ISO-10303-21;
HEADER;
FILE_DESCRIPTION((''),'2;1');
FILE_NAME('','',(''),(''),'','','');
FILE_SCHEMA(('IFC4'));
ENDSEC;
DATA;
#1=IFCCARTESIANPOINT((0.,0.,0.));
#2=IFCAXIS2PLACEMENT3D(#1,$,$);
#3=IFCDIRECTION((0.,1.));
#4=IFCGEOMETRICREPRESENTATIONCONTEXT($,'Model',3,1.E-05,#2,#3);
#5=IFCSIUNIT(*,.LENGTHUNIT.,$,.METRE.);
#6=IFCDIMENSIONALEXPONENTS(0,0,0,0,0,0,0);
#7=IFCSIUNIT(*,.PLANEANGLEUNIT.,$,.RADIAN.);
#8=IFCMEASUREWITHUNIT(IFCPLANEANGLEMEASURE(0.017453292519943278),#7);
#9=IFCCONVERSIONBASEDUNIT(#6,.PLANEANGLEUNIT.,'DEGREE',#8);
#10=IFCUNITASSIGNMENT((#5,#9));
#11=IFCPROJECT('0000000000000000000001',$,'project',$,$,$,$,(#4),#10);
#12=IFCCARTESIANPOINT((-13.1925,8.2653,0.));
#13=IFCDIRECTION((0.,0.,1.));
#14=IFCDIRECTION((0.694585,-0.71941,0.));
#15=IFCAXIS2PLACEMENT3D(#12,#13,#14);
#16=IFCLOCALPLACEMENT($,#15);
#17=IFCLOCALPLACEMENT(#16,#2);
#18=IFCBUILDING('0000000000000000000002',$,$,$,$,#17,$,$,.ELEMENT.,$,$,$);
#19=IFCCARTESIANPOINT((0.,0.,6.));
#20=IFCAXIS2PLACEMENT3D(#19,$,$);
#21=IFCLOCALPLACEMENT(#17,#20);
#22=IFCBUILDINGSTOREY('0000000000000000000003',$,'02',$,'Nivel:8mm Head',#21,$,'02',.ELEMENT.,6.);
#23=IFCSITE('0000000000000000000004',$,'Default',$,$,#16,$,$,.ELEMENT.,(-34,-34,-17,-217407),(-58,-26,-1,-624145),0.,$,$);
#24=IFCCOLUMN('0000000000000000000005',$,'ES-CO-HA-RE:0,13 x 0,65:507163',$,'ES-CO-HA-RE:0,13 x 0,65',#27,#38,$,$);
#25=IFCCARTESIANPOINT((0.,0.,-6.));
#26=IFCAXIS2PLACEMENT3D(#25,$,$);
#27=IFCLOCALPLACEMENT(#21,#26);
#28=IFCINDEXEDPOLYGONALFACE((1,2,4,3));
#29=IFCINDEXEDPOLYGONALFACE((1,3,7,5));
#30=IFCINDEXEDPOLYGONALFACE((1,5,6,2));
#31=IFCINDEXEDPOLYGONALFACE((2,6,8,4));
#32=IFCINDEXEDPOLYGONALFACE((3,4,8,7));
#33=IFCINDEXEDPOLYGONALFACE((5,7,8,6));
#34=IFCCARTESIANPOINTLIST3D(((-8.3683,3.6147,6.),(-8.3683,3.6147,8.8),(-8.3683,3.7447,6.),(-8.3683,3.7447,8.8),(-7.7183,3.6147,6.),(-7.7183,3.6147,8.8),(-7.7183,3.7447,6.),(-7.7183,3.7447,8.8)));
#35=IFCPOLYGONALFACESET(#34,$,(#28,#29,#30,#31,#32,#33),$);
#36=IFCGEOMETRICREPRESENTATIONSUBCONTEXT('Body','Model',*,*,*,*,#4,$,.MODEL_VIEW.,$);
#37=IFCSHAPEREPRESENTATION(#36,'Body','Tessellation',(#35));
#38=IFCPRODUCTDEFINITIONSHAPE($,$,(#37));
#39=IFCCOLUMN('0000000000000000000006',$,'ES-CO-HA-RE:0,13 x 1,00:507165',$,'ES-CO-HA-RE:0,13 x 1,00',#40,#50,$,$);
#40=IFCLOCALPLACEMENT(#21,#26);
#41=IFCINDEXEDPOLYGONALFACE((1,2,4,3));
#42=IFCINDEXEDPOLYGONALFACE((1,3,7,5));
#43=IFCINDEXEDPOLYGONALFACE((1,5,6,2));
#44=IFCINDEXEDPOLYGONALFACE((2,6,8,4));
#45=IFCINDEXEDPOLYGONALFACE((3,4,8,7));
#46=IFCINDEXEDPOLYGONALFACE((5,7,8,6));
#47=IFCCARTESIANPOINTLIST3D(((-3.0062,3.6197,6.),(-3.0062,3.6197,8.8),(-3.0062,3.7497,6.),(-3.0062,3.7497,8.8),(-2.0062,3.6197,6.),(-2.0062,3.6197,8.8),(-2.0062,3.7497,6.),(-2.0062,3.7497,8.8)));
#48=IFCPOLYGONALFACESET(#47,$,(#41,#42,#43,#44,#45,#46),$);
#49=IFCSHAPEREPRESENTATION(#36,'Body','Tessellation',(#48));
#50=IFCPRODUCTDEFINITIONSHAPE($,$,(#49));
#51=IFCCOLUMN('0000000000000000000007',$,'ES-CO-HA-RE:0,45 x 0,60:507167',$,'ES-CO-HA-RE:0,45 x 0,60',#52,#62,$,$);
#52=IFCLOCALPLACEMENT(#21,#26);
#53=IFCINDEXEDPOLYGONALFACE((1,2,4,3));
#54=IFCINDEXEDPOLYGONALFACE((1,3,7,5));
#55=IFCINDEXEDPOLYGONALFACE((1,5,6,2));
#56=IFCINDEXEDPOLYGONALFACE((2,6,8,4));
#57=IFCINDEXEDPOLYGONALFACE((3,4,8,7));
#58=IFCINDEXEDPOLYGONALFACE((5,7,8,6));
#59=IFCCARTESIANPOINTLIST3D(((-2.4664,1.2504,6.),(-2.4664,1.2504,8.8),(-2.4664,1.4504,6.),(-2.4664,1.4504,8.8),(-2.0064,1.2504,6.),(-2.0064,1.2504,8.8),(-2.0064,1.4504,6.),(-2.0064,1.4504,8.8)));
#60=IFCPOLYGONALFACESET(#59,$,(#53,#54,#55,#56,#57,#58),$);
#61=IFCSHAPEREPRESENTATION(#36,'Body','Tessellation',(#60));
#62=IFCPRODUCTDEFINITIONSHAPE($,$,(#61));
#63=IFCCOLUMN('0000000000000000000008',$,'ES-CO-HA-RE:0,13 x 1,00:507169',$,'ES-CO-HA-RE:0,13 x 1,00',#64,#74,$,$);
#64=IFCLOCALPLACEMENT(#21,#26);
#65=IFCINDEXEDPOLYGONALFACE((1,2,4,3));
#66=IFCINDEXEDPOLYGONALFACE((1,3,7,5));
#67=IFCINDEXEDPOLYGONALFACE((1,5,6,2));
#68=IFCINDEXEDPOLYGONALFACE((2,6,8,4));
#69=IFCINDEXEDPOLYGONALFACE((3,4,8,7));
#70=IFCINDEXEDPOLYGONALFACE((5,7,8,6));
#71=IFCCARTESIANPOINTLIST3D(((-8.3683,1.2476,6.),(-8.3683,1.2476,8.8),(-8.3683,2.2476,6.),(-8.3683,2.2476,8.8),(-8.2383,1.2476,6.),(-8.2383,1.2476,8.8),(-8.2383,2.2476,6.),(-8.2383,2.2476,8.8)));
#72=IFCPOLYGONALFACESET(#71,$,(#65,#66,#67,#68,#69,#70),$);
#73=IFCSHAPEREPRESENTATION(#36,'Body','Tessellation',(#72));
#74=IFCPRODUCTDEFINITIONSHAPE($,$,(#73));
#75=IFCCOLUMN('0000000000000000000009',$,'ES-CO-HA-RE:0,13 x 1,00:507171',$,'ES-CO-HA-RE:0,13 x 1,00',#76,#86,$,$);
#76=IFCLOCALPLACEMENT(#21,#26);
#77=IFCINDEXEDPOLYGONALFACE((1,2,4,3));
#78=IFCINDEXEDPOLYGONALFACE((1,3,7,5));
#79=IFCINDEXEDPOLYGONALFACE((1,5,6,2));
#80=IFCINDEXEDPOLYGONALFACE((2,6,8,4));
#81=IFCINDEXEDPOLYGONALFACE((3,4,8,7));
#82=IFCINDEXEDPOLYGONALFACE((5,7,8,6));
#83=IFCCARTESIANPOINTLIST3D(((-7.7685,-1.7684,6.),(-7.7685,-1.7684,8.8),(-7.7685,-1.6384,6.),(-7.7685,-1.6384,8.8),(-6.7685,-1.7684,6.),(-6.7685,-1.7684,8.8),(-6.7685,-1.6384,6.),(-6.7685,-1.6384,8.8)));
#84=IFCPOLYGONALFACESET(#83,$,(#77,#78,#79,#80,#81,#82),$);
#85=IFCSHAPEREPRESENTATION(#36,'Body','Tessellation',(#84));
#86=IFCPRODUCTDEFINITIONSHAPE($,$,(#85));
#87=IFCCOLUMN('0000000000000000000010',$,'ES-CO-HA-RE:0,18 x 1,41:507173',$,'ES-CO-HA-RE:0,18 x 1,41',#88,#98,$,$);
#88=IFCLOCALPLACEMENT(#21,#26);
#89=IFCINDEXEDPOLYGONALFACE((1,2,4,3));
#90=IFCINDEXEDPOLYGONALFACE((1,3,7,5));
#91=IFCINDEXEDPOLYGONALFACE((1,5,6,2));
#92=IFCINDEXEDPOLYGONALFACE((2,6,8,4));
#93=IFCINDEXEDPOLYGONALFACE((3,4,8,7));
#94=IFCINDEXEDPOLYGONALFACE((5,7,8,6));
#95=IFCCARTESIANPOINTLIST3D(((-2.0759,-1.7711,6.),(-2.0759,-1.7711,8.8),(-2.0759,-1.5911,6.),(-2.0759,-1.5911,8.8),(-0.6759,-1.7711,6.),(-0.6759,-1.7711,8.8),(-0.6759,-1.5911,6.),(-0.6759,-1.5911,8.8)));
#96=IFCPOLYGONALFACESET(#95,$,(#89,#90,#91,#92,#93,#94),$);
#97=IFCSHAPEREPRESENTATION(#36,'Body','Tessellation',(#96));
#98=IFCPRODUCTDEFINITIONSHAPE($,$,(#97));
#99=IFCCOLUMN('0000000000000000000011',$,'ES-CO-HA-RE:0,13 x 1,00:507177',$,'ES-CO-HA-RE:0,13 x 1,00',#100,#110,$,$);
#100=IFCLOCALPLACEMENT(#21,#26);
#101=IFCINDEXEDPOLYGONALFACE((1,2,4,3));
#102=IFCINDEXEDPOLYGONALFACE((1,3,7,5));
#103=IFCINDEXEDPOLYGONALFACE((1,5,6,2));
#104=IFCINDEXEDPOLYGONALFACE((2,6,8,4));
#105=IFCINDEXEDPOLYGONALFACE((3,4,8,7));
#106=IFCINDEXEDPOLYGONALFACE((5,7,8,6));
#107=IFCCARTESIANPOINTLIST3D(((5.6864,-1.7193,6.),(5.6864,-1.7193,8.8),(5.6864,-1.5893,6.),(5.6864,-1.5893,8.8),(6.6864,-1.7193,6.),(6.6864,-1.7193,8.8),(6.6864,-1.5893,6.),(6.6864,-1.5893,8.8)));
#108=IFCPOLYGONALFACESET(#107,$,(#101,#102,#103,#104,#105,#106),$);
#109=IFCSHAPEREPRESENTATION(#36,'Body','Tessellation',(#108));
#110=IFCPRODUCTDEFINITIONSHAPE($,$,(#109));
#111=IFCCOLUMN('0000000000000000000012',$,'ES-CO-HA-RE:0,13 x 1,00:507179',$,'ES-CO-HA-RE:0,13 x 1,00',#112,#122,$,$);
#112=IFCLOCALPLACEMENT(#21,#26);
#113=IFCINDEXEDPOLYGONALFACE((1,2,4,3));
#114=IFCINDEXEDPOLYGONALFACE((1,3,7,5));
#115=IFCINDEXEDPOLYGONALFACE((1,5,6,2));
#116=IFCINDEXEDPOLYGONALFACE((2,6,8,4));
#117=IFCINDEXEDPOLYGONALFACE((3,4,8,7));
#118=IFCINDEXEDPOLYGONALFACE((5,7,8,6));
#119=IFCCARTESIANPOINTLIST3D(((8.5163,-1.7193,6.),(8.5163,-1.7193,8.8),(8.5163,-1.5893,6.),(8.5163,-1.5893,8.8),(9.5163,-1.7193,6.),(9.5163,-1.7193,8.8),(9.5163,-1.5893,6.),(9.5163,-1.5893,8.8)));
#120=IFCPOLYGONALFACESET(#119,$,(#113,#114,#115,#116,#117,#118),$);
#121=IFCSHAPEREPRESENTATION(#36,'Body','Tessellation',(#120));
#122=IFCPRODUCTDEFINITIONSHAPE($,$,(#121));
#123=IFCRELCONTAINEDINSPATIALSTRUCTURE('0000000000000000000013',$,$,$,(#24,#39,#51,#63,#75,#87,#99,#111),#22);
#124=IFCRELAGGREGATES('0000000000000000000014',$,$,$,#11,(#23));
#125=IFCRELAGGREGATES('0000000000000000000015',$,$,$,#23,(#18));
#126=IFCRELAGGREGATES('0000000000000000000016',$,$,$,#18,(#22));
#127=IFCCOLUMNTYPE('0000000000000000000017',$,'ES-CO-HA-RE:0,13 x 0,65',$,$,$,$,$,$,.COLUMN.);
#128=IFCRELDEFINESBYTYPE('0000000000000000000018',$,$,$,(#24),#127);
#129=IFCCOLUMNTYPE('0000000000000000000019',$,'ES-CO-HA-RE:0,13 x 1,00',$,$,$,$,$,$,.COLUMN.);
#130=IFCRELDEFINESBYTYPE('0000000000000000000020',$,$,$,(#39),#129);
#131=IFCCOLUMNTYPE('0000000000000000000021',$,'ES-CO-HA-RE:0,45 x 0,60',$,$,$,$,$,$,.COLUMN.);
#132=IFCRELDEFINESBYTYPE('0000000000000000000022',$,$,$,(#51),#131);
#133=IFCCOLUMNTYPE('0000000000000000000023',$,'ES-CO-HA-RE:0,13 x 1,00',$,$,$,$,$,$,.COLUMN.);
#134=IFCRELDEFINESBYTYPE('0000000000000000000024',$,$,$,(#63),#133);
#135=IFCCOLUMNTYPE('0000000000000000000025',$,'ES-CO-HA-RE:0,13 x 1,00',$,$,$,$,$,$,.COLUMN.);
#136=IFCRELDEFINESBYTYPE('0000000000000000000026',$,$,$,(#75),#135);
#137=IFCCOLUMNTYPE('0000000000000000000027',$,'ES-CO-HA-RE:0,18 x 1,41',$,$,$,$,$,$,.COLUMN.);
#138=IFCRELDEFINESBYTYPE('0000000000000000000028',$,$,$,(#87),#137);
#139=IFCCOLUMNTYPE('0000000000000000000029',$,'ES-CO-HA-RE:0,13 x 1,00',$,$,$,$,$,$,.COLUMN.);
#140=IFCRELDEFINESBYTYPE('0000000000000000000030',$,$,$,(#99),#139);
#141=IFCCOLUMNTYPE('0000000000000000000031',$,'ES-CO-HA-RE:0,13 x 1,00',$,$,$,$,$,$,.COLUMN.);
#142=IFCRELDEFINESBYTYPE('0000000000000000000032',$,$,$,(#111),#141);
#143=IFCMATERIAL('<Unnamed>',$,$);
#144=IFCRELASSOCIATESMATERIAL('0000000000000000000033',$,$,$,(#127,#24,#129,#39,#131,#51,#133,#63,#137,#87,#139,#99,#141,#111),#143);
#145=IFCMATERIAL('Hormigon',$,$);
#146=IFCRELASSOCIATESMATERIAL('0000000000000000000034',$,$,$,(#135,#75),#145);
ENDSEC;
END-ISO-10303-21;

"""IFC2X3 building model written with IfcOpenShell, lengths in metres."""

from ifc_helpers import new_model, entity, si_unit, converted_unit, direction, frame, frame_2d, origin, origin_2d_with_axis, place, context, subcontext, project, spatial, rectangle, extrude, source, transform, mapped, material, type_object, type_shapes, element, save


model = new_model("IFC2X3")

# Units and contexts
model_context = context("Model", 3, precision=1e-05, world=origin(), true_north=direction((0.0, 1.0)))
body_context = subcontext(model_context, "Body", "Model", "MODEL_VIEW")
ifc_project = project(units=[si_unit("LENGTHUNIT", "METRE"), converted_unit("PLANEANGLEUNIT", "DEGREE", entity("IfcPlaneAngleMeasure", 0.017453292519943278), si_unit("PLANEANGLEUNIT", "RADIAN"), dimensions=[0, 0, 0, 0, 0, 0, 0])], contexts=[model_context])

# Site, building, storey
site_placement = place(None, frame((-13.1925, 8.2653, 0.0), z_axis=(0.0, 0.0, 1.0), x_axis=(0.694585, -0.71941, 0.0)))
site = spatial("IfcSite", under=ifc_project, at=site_placement, Name="Default", CompositionType="ELEMENT", RefLatitude=(-34, -34, -17, -217407), RefLongitude=(-58, -26, -1, -624145), RefElevation=0.0)
building_placement = place(site_placement, origin())
building = spatial("IfcBuilding", under=site, at=building_placement, CompositionType="ELEMENT")
storey_placement = place(building_placement, frame((0.0, 0.0, 6.0)))
storey = spatial("IfcBuildingStorey", under=building, at=storey_placement, Name="02", ObjectType="Nivel:8mm Head", LongName="02", CompositionType="ELEMENT", Elevation=6.0)

# Columns
ifc_material_1 = material(Name="<Unnamed>")
column_type_1 = type_object("IfcColumnType", Name="ES-CO-HA-RE:0,13 x 0,65", PredefinedType="COLUMN", material=ifc_material_1)
shared_shape_1 = source(origin(), body_context, "Body", "SweptSolid", [
    extrude(rectangle(XDim=0.65, YDim=0.13, at=origin_2d_with_axis()), frame((-8.0433, 3.6797, 6.0), z_axis=(0.0, 0.0, 1.0), x_axis=(-1.0, 0.0, 0.0)), (0.0, 0.0, 1.0), 2.8),
])
type_shapes(column_type_1, [shared_shape_1])
column_1_placement = place(storey_placement, frame((0.0, 0.0, -6.0)))
element("IfcColumn", 1, at=column_1_placement, inside=storey, type_object=column_type_1, material=ifc_material_1, Name="ES-CO-HA-RE:0,13 x 0,65:507163", ObjectType="ES-CO-HA-RE:0,13 x 0,65", context=body_context, shape_type="MappedRepresentation", body=[
    mapped(shared_shape_1, transform((0.0, 0.0, 0.0), scale=1.0)),
])
column_type_2 = type_object("IfcColumnType", Name="ES-CO-HA-RE:0,13 x 1,00", PredefinedType="COLUMN", material=ifc_material_1)
shared_shape_2 = source(origin(), body_context, "Body", "SweptSolid", [
    extrude(rectangle(XDim=1.0, YDim=0.13, at=frame_2d((0.0, 0.0), x_axis=(1.0, 0.0))), frame((-2.5062, 3.6847, 6.0), z_axis=(0.0, 0.0, 1.0), x_axis=(-1.0, 0.0, 0.0)), (0.0, 0.0, 1.0), 2.8),
])
type_shapes(column_type_2, [shared_shape_2])
column_2_placement = place(storey_placement, frame((0.0, 0.0, -6.0)))
element("IfcColumn", 2, at=column_2_placement, inside=storey, type_object=column_type_2, material=ifc_material_1, Name="ES-CO-HA-RE:0,13 x 1,00:507165", ObjectType="ES-CO-HA-RE:0,13 x 1,00", context=body_context, shape_type="MappedRepresentation", body=[
    mapped(shared_shape_2, transform((0.0, 0.0, 0.0), scale=1.0)),
])
column_type_3 = type_object("IfcColumnType", Name="ES-CO-HA-RE:0,45 x 0,60", PredefinedType="COLUMN", material=ifc_material_1)
shared_shape_3 = source(origin(), body_context, "Body", "SweptSolid", [
    extrude(rectangle(XDim=0.46, YDim=0.2, at=frame_2d((0.0, 0.0), x_axis=(1.0, 0.0))), frame((-2.2364, 1.3504, 6.0), z_axis=(0.0, 0.0, 1.0), x_axis=(-1.0, 0.0, 0.0)), (0.0, 0.0, 1.0), 2.8),
])
type_shapes(column_type_3, [shared_shape_3])
column_3_placement = place(storey_placement, frame((0.0, 0.0, -6.0)))
element("IfcColumn", 3, at=column_3_placement, inside=storey, type_object=column_type_3, material=ifc_material_1, Name="ES-CO-HA-RE:0,45 x 0,60:507167", ObjectType="ES-CO-HA-RE:0,45 x 0,60", context=body_context, shape_type="MappedRepresentation", body=[
    mapped(shared_shape_3, transform((0.0, 0.0, 0.0), scale=1.0)),
])
column_type_4 = type_object("IfcColumnType", Name="ES-CO-HA-RE:0,13 x 1,00", PredefinedType="COLUMN", material=ifc_material_1)
shared_shape_4 = source(origin(), body_context, "Body", "SweptSolid", [
    extrude(rectangle(XDim=1.0, YDim=0.13, at=frame_2d((0.0, 0.0), x_axis=(1.0, 0.0))), frame((-8.3033, 1.7476, 6.0), z_axis=(0.0, 0.0, 1.0), x_axis=(0.0, -1.0, 0.0)), (0.0, 0.0, 1.0), 2.8),
])
type_shapes(column_type_4, [shared_shape_4])
column_4_placement = place(storey_placement, frame((0.0, 0.0, -6.0)))
element("IfcColumn", 4, at=column_4_placement, inside=storey, type_object=column_type_4, material=ifc_material_1, Name="ES-CO-HA-RE:0,13 x 1,00:507169", ObjectType="ES-CO-HA-RE:0,13 x 1,00", context=body_context, shape_type="MappedRepresentation", body=[
    mapped(shared_shape_4, transform((0.0, 0.0, 0.0), scale=1.0)),
])
ifc_material_2 = material(Name="Hormigon")
column_type_5 = type_object("IfcColumnType", Name="ES-CO-HA-RE:0,13 x 1,00", PredefinedType="COLUMN", material=ifc_material_2)
shared_shape_5 = source(origin(), body_context, "Body", "SweptSolid", [
    extrude(rectangle(XDim=1.0, YDim=0.13, at=frame_2d((0.0, 0.0), x_axis=(1.0, 0.0))), frame((-7.2685, -1.7034, 6.0), z_axis=(0.0, 0.0, 1.0), x_axis=(-1.0, 0.0, 0.0)), (0.0, 0.0, 1.0), 2.8),
])
type_shapes(column_type_5, [shared_shape_5])
column_5_placement = place(storey_placement, frame((0.0, 0.0, -6.0)))
element("IfcColumn", 5, at=column_5_placement, inside=storey, type_object=column_type_5, material=ifc_material_2, Name="ES-CO-HA-RE:0,13 x 1,00:507171", ObjectType="ES-CO-HA-RE:0,13 x 1,00", context=body_context, shape_type="MappedRepresentation", body=[
    mapped(shared_shape_5, transform((0.0, 0.0, 0.0), scale=1.0)),
])
column_type_6 = type_object("IfcColumnType", Name="ES-CO-HA-RE:0,18 x 1,41", PredefinedType="COLUMN", material=ifc_material_1)
shared_shape_6 = source(origin(), body_context, "Body", "SweptSolid", [
    extrude(rectangle(XDim=1.4, YDim=0.18, at=frame_2d((0.0, 0.0), x_axis=(1.0, 0.0))), frame((-1.3759, -1.6811, 6.0), z_axis=(0.0, 0.0, 1.0), x_axis=(-1.0, 0.0, 0.0)), (0.0, 0.0, 1.0), 2.8),
])
type_shapes(column_type_6, [shared_shape_6])
column_6_placement = place(storey_placement, frame((0.0, 0.0, -6.0)))
element("IfcColumn", 6, at=column_6_placement, inside=storey, type_object=column_type_6, material=ifc_material_1, Name="ES-CO-HA-RE:0,18 x 1,41:507173", ObjectType="ES-CO-HA-RE:0,18 x 1,41", context=body_context, shape_type="MappedRepresentation", body=[
    mapped(shared_shape_6, transform((0.0, 0.0, 0.0), scale=1.0)),
])
column_type_7 = type_object("IfcColumnType", Name="ES-CO-HA-RE:0,13 x 1,00", PredefinedType="COLUMN", material=ifc_material_1)
shared_shape_7 = source(origin(), body_context, "Body", "SweptSolid", [
    extrude(rectangle(XDim=1.0, YDim=0.13, at=frame_2d((0.0, 0.0), x_axis=(1.0, 0.0))), frame((6.1864, -1.6543, 6.0), z_axis=(0.0, 0.0, 1.0), x_axis=(-1.0, 0.0, 0.0)), (0.0, 0.0, 1.0), 2.8),
])
type_shapes(column_type_7, [shared_shape_7])
column_7_placement = place(storey_placement, frame((0.0, 0.0, -6.0)))
element("IfcColumn", 7, at=column_7_placement, inside=storey, type_object=column_type_7, material=ifc_material_1, Name="ES-CO-HA-RE:0,13 x 1,00:507177", ObjectType="ES-CO-HA-RE:0,13 x 1,00", context=body_context, shape_type="MappedRepresentation", body=[
    mapped(shared_shape_7, transform((0.0, 0.0, 0.0), scale=1.0)),
])
column_type_8 = type_object("IfcColumnType", Name="ES-CO-HA-RE:0,13 x 1,00", PredefinedType="COLUMN", material=ifc_material_1)
shared_shape_8 = source(origin(), body_context, "Body", "SweptSolid", [
    extrude(rectangle(XDim=1.0, YDim=0.13, at=frame_2d((0.0, 0.0), x_axis=(1.0, 0.0))), frame((9.0163, -1.6543, 6.0), z_axis=(0.0, 0.0, 1.0), x_axis=(-1.0, 0.0, 0.0)), (0.0, 0.0, 1.0), 2.8),
])
type_shapes(column_type_8, [shared_shape_8])
column_8_placement = place(storey_placement, frame((0.0, 0.0, -6.0)))
element("IfcColumn", 8, at=column_8_placement, inside=storey, type_object=column_type_8, material=ifc_material_1, Name="ES-CO-HA-RE:0,13 x 1,00:507179", ObjectType="ES-CO-HA-RE:0,13 x 1,00", context=body_context, shape_type="MappedRepresentation", body=[
    mapped(shared_shape_8, transform((0.0, 0.0, 0.0), scale=1.0)),
])

save(model, "model.ifc")
